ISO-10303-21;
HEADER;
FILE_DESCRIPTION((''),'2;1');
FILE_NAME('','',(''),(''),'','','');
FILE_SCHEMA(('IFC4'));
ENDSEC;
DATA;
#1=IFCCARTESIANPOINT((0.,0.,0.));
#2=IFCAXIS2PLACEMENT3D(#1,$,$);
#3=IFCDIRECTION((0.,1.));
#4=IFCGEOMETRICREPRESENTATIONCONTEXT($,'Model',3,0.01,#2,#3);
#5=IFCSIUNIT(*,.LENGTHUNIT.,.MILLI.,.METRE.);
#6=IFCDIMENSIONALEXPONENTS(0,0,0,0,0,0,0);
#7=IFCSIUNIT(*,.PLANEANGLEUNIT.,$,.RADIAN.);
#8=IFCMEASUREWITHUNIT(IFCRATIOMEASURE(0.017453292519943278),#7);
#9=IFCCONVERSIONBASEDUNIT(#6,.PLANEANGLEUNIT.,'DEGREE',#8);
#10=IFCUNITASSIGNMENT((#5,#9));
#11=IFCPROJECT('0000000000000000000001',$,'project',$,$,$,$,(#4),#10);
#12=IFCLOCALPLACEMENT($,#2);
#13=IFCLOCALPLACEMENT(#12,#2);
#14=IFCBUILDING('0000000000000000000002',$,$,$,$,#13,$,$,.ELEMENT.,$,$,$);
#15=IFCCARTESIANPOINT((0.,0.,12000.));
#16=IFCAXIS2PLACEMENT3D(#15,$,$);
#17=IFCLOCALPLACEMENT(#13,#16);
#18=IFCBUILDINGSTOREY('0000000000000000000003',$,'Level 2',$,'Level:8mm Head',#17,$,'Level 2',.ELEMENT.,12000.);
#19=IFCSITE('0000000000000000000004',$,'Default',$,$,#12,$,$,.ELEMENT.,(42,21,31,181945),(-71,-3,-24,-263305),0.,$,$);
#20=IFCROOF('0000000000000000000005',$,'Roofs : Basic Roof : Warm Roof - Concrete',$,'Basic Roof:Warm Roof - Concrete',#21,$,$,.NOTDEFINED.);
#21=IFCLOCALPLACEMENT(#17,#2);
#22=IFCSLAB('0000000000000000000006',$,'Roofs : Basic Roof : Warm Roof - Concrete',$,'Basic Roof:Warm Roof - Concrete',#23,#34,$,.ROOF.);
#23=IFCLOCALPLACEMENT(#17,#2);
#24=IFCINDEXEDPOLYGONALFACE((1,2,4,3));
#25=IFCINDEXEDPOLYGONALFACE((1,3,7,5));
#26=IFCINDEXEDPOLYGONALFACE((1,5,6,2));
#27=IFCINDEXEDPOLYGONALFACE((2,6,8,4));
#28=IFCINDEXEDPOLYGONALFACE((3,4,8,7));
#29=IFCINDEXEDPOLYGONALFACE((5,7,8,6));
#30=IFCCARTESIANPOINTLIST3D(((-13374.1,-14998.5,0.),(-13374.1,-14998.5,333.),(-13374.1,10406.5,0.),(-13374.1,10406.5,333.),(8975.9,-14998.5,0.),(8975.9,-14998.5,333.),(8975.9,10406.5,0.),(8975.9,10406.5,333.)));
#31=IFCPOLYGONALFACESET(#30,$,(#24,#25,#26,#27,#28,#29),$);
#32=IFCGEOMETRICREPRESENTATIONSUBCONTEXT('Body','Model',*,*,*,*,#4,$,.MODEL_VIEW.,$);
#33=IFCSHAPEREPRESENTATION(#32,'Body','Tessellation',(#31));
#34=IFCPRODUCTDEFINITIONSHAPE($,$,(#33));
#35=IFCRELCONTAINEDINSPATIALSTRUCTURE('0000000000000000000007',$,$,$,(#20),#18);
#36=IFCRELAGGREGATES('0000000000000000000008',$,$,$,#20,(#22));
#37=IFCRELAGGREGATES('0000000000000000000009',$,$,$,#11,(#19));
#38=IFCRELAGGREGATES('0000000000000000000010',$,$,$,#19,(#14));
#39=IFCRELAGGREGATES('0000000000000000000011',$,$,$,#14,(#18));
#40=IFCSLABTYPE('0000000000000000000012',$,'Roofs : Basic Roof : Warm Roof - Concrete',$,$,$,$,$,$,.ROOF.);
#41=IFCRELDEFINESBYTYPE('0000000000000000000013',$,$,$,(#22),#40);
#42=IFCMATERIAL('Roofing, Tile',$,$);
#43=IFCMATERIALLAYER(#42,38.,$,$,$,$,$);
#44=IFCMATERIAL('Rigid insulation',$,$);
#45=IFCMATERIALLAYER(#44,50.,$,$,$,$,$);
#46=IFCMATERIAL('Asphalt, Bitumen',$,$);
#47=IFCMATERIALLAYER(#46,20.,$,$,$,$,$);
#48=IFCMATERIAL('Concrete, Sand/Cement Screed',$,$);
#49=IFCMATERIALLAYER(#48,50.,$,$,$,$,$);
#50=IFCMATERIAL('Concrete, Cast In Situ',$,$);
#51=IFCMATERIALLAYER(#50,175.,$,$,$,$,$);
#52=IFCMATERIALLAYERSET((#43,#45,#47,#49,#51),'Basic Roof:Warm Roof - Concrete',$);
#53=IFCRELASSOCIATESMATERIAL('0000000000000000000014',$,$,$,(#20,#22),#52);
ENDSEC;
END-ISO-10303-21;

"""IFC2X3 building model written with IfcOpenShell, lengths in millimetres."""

from ifc_helpers import new_model, entity, si_unit, converted_unit, direction, frame, frame_2d, origin, place, context, subcontext, project, spatial, rectangle, extrude, material, layer, layer_set, type_object, element, aggregate, save


model = new_model("IFC2X3")

# Units and contexts
model_context = context("Model", 3, precision=0.01, world=origin(), true_north=direction((0.0, 1.0)))
body_context = subcontext(model_context, "Body", "Model", "MODEL_VIEW")
ifc_project = project(units=[si_unit("LENGTHUNIT", "METRE", prefix="MILLI"), converted_unit("PLANEANGLEUNIT", "DEGREE", entity("IfcRatioMeasure", 0.017453292519943278), si_unit("PLANEANGLEUNIT", "RADIAN"), dimensions=[0, 0, 0, 0, 0, 0, 0])], contexts=[model_context])

# Site, building, storey
site_placement = place(None, origin())
site = spatial("IfcSite", under=ifc_project, at=site_placement, Name="Default", CompositionType="ELEMENT", RefLatitude=(42, 21, 31, 181945), RefLongitude=(-71, -3, -24, -263305), RefElevation=0.0)
building_placement = place(site_placement, origin())
building = spatial("IfcBuilding", under=site, at=building_placement, CompositionType="ELEMENT")
storey_placement = place(building_placement, frame((0.0, 0.0, 12000.0)))
storey = spatial("IfcBuildingStorey", under=building, at=storey_placement, Name="Level 2", ObjectType="Level:8mm Head", LongName="Level 2", CompositionType="ELEMENT", Elevation=12000.0)

# Roof, slab
ifc_material_1 = material(Name="Roofing, Tile")
ifc_layer_1 = layer(ifc_material_1, 38.0)
ifc_material_2 = material(Name="Rigid insulation")
ifc_layer_2 = layer(ifc_material_2, 50.0)
ifc_material_3 = material(Name="Asphalt, Bitumen")
ifc_layer_3 = layer(ifc_material_3, 20.0)
ifc_material_4 = material(Name="Concrete, Sand/Cement Screed")
ifc_layer_4 = layer(ifc_material_4, 50.0)
ifc_material_5 = material(Name="Concrete, Cast In Situ")
ifc_layer_5 = layer(ifc_material_5, 175.0)
ifc_layer_set = layer_set([ifc_layer_1, ifc_layer_2, ifc_layer_3, ifc_layer_4, ifc_layer_5], Name="Basic Roof:Warm Roof - Concrete")
roof_placement = place(storey_placement, frame((-13374.1, -14998.5, 0.0)))
roof = element("IfcRoof", 1, at=roof_placement, inside=storey, material=ifc_layer_set, Name="Roofs : Basic Roof : Warm Roof - Concrete", ObjectType="Basic Roof:Warm Roof - Concrete", ShapeType="NOTDEFINED")
slab_type = type_object("IfcSlabType", Name="Roofs : Basic Roof : Warm Roof - Concrete", PredefinedType="ROOF")
slab_placement = place(roof_placement, origin())
slab = element("IfcSlab", 2, at=slab_placement, type_object=slab_type, material=ifc_layer_set, Name="Roofs : Basic Roof : Warm Roof - Concrete", ObjectType="Basic Roof:Warm Roof - Concrete", PredefinedType="ROOF", context=body_context, shape_type="SweptSolid", body=[
    extrude(rectangle(XDim=22350.0, YDim=25405.0, at=frame_2d((0.0, 0.0), x_axis=(1.0, 0.0))), frame((11175.0, 12702.5, 0.0)), (0.0, 0.0, 1.0), 333.0),
])
aggregate(roof, [slab])

save(model, "model.ifc")
